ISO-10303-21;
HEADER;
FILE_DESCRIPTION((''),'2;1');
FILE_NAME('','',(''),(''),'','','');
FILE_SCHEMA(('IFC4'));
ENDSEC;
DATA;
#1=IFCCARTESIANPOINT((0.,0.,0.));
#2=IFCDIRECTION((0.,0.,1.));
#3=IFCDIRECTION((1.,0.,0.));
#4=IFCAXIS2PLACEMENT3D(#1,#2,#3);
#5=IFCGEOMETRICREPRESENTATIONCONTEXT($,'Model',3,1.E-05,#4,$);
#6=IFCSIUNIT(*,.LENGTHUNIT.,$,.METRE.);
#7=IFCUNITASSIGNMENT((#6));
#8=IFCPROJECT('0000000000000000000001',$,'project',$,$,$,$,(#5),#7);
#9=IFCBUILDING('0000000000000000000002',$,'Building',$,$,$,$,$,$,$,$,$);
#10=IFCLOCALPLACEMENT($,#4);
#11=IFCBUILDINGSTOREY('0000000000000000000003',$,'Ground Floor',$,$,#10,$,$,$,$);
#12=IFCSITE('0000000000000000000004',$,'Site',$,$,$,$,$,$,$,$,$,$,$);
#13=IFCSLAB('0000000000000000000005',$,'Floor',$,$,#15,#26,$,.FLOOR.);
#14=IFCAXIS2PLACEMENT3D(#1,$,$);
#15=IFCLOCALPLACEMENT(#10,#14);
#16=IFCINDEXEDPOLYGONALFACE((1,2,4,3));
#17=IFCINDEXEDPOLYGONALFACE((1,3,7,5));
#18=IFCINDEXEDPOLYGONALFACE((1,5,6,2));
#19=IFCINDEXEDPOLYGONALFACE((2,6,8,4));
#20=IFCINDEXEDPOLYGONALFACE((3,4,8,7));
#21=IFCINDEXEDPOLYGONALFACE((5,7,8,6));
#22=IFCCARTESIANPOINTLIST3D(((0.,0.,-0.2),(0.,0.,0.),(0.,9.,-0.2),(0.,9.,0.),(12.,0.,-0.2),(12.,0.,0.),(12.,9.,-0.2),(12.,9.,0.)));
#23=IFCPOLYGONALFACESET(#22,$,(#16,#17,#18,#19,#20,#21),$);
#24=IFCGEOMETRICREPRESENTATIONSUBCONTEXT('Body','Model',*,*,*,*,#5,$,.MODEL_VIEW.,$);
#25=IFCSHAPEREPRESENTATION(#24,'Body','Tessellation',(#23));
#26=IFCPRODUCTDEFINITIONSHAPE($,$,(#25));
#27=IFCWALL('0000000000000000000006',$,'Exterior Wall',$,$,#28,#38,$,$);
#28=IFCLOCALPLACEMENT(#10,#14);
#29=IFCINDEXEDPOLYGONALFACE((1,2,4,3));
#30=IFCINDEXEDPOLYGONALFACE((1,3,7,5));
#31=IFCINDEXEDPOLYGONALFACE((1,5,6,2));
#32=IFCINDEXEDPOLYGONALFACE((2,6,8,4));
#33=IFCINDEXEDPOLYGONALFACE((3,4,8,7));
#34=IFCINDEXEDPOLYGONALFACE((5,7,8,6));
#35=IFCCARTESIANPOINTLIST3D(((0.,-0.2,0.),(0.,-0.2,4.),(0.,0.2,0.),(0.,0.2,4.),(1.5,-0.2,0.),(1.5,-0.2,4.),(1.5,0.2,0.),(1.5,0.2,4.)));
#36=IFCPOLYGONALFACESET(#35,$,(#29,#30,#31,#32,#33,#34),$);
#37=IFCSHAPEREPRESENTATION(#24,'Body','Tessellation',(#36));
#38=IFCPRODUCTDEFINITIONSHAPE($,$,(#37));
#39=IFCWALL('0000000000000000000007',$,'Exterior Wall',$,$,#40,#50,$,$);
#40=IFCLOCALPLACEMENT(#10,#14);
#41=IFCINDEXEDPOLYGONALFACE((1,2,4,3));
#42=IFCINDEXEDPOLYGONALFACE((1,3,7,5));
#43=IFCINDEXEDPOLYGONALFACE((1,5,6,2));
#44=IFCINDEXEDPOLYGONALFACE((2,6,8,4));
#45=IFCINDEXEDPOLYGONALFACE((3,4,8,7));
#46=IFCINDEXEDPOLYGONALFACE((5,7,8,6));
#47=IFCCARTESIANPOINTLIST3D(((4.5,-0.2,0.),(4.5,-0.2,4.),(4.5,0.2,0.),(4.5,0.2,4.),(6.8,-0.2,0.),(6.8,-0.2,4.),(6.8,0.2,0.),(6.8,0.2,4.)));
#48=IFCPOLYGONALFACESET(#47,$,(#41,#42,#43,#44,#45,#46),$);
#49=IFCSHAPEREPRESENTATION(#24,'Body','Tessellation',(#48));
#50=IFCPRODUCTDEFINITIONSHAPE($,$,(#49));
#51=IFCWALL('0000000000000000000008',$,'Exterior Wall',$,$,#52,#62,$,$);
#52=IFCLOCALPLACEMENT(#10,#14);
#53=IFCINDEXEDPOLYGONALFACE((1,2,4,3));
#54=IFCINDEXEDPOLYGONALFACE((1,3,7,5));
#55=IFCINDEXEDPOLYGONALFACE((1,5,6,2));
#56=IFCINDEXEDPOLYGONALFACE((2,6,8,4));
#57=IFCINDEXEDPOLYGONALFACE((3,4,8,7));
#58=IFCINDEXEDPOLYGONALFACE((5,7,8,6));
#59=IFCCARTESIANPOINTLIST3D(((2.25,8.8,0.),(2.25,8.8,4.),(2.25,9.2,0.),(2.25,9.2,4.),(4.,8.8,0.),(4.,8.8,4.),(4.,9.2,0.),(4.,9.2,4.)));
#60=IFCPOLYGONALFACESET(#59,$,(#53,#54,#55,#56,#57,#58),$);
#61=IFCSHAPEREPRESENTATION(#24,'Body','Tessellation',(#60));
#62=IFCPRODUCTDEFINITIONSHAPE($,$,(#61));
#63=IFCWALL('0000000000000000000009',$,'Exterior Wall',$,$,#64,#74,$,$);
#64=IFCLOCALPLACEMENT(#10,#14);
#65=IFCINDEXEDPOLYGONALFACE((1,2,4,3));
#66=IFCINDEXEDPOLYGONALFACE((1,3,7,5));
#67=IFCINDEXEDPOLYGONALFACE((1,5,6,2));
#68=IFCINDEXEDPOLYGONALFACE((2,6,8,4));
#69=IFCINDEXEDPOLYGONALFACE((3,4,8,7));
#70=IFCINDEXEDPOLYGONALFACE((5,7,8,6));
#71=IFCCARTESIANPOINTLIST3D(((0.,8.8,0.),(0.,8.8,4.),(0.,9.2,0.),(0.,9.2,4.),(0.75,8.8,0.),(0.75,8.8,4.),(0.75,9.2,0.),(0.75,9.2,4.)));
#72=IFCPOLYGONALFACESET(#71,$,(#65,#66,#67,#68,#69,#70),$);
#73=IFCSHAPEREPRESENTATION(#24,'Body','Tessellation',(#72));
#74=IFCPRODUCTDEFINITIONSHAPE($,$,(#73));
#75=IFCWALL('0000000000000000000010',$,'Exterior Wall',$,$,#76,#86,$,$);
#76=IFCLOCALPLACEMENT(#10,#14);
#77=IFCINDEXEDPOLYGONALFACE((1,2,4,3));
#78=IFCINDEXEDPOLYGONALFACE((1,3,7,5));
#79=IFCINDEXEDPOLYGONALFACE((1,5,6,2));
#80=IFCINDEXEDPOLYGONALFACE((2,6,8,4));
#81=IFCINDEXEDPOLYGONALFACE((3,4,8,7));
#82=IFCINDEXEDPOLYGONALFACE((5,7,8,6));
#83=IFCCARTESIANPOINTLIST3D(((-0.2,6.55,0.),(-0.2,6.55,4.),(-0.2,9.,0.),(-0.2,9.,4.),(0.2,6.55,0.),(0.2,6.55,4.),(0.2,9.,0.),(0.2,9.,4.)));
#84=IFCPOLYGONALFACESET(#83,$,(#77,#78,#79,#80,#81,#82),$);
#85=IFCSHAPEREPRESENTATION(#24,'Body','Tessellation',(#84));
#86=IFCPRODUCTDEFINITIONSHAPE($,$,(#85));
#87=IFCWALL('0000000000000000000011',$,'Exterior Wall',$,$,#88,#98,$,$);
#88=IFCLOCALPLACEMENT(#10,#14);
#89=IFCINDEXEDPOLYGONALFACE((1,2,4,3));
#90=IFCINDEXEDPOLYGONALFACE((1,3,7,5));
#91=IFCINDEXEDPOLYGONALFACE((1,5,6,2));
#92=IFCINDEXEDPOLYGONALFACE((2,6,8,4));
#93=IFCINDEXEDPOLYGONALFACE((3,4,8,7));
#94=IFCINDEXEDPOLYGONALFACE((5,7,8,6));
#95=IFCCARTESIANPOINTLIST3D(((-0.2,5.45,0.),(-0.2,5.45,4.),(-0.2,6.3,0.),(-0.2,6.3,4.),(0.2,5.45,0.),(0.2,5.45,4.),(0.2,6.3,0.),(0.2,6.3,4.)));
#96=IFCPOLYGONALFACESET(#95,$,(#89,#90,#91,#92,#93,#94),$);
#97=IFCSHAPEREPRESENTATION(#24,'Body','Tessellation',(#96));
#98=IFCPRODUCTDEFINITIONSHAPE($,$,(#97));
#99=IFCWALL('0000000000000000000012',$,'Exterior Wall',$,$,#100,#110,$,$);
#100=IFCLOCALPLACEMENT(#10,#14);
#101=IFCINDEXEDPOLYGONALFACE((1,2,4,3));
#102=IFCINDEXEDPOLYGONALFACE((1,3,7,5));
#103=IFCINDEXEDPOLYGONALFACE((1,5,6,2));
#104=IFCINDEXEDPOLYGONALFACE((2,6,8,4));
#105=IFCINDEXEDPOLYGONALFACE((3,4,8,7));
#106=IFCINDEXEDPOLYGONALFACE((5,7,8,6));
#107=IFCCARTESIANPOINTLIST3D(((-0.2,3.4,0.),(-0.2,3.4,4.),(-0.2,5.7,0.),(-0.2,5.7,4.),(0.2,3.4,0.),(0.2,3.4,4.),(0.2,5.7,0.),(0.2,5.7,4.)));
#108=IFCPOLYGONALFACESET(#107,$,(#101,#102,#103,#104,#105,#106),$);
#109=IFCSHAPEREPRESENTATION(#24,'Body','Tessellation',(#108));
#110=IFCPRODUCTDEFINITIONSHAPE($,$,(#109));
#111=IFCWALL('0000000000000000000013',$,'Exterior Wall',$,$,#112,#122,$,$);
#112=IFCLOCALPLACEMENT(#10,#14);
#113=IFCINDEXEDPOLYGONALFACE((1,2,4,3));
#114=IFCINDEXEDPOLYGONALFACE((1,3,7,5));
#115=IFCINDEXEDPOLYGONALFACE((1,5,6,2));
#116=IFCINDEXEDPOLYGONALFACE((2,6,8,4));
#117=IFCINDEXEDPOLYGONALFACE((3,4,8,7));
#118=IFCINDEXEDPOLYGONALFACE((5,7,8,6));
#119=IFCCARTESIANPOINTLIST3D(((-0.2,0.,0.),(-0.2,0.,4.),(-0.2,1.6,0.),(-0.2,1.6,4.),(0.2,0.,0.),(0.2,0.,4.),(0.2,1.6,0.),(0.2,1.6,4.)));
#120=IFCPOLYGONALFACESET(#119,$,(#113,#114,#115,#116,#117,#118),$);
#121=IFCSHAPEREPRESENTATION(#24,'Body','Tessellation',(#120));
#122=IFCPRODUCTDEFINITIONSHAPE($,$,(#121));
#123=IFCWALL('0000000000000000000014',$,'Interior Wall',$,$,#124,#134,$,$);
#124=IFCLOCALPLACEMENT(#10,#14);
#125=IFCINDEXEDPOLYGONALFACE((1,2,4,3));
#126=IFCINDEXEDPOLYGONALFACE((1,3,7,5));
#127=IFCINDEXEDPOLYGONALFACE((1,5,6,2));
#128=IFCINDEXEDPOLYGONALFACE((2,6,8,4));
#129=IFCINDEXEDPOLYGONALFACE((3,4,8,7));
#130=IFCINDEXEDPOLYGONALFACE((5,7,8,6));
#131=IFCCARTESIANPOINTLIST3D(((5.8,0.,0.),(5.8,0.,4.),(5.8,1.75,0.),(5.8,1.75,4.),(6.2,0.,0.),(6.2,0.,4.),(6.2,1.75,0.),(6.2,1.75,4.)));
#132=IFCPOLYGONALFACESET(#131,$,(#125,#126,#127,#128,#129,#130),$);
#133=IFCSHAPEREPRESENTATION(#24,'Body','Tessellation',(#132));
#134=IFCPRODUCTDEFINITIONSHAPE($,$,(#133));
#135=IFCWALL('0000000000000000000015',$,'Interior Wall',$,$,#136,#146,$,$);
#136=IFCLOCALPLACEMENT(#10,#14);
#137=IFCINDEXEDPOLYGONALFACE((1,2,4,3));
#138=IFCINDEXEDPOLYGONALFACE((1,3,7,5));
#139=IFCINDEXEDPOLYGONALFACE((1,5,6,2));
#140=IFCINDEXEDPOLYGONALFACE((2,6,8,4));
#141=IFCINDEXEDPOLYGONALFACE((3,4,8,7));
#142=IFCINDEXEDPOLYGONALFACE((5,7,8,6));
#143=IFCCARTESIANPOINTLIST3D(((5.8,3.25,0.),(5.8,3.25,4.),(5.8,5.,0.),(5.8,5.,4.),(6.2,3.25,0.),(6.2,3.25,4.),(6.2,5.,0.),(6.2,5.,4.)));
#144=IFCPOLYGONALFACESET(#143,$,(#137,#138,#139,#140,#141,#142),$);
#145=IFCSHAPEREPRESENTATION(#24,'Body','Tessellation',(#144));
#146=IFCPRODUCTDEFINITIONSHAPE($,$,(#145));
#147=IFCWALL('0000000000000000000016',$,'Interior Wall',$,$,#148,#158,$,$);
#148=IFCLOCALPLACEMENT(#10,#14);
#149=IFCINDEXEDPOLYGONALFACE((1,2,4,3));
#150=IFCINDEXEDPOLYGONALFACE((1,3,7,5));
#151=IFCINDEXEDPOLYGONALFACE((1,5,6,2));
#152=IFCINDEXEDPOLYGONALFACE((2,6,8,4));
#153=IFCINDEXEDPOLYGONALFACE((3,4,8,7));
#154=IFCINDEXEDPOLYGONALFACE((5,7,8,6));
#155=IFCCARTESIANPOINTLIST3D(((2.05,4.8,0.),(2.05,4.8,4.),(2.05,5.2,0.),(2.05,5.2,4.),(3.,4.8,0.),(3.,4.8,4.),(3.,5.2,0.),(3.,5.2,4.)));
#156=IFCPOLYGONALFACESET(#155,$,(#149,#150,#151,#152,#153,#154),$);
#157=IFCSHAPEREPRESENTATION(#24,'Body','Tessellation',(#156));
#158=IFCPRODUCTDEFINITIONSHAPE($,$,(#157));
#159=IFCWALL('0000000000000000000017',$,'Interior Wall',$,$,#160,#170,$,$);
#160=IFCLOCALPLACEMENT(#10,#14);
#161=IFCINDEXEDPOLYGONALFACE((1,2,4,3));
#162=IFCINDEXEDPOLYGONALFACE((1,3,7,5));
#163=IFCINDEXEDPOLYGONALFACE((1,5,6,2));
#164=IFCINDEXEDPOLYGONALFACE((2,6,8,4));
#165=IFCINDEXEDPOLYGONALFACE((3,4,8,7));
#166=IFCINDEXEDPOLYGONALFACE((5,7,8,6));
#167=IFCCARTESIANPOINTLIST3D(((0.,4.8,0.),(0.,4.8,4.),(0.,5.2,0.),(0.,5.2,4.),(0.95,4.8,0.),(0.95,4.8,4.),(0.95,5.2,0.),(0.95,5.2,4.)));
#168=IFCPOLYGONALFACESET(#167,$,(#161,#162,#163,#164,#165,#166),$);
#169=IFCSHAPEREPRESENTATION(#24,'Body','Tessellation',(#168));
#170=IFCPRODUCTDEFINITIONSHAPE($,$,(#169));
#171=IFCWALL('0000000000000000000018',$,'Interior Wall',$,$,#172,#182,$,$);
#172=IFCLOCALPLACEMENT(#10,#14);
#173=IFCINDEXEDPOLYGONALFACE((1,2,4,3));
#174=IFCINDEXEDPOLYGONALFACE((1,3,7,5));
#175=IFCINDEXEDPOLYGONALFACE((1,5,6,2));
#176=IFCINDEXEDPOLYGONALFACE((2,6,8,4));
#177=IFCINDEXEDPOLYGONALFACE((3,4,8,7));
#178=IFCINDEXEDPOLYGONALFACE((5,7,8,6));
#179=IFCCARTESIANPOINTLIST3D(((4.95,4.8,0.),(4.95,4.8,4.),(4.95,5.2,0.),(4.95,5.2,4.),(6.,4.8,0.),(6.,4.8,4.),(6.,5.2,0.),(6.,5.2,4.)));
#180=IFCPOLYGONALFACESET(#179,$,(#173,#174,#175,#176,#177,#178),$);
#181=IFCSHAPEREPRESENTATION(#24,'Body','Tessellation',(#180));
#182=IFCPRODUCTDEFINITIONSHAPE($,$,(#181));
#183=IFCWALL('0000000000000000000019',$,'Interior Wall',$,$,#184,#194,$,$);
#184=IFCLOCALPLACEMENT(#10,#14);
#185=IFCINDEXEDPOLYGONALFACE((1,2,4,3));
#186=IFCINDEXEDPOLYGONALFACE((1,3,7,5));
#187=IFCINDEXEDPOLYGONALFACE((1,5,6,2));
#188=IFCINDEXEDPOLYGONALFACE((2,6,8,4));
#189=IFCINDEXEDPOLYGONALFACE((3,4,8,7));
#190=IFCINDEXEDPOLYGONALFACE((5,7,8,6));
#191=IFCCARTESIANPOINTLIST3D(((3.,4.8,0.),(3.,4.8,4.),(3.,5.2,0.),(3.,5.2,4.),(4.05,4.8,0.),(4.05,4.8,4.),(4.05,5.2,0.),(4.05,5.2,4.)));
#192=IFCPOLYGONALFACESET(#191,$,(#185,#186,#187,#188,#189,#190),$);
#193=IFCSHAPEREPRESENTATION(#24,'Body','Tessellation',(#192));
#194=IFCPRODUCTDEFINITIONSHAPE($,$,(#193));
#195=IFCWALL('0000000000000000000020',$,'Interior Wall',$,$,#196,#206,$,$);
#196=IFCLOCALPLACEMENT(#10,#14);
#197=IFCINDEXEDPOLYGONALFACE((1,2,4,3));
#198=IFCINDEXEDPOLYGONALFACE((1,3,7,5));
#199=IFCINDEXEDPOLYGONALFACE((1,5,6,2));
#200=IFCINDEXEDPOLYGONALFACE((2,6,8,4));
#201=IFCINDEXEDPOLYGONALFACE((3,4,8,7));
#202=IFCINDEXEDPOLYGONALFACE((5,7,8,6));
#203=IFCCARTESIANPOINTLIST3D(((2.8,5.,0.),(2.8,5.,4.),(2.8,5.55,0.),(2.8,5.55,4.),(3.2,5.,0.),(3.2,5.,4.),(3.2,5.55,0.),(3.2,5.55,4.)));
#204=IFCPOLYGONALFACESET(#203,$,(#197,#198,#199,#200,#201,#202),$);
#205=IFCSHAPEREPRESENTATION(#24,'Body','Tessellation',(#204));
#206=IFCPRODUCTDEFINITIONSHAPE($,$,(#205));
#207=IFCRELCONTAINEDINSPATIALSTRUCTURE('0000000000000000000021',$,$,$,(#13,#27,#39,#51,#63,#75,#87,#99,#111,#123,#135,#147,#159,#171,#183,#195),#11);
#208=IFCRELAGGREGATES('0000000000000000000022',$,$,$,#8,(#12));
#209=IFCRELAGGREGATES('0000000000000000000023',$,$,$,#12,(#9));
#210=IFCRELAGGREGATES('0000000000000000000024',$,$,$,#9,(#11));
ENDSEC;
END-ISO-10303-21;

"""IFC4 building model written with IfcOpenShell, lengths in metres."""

from ifc_helpers import new_model, si_unit, frame, origin_with_axes, place, context, subcontext, project, spatial, indexed_curve, outline, extrude, element, save


model = new_model("IFC4")

# Units and contexts
model_context = context("Model", 3, precision=1e-05, world=origin_with_axes())
body_context = subcontext(model_context, "Body", "Model", "MODEL_VIEW")
ifc_project = project(units=[si_unit("LENGTHUNIT", "METRE")], contexts=[model_context])

# Site, building, storey
site = spatial("IfcSite", under=ifc_project, Name="Site")
building = spatial("IfcBuilding", under=site, Name="Building")
storey_placement = place(None, origin_with_axes())
storey = spatial("IfcBuildingStorey", under=building, at=storey_placement, Name="Ground Floor")

# Slab
slab_placement = place(storey_placement, frame((0.0, 0.0, -0.2), z_axis=(0.0, 0.0, 1.0), x_axis=(1.0, 0.0, 0.0)))
element("IfcSlab", 1, at=slab_placement, inside=storey, Name="Floor", PredefinedType="FLOOR", context=body_context, shape_type="SweptSolid", body=[
    extrude(outline(indexed_curve([(0.0, 0.0), (12.0, 0.0), (12.0, 9.0), (0.0, 9.0)])), None, (0.0, 0.0, 1.0), 0.2),
])

# Walls
wall_1_placement = place(storey_placement, origin_with_axes())
element("IfcWall", 2, at=wall_1_placement, inside=storey, Name="Exterior Wall", context=body_context, shape_type="SweptSolid", body=[
    extrude(outline(indexed_curve([(0.0, 0.0), (0.0, 0.4), (1.5, 0.4), (1.5, 0.0), (0.0, 0.0)], self_intersect=False)), frame((0.0, -0.2, 0.0), z_axis=(0.0, 0.0, 1.0), x_axis=(1.0, 0.0, 0.0)), (0.0, 0.0, 1.0), 4.0),
])
wall_2_placement = place(storey_placement, frame((4.5, 0.0, 0.0), z_axis=(0.0, 0.0, 1.0), x_axis=(1.0, 0.0, 0.0)))
element("IfcWall", 3, at=wall_2_placement, inside=storey, Name="Exterior Wall", context=body_context, shape_type="SweptSolid", body=[
    extrude(outline(indexed_curve([(0.0, 0.0), (0.0, 0.4), (2.3, 0.4), (2.3, 0.0), (0.0, 0.0)], self_intersect=False)), frame((0.0, -0.2, 0.0), z_axis=(0.0, 0.0, 1.0), x_axis=(1.0, 0.0, 0.0)), (0.0, 0.0, 1.0), 4.0),
])
wall_3_placement = place(storey_placement, frame((4.0, 9.0, 0.0), z_axis=(0.0, 0.0, 1.0), x_axis=(-1.0, 0.0, 0.0)))
element("IfcWall", 4, at=wall_3_placement, inside=storey, Name="Exterior Wall", context=body_context, shape_type="SweptSolid", body=[
    extrude(outline(indexed_curve([(0.0, 0.0), (0.0, 0.4), (1.75, 0.4), (1.75, 0.0), (0.0, 0.0)], self_intersect=False)), frame((0.0, -0.2, 0.0), z_axis=(0.0, 0.0, 1.0), x_axis=(1.0, 0.0, 0.0)), (0.0, 0.0, 1.0), 4.0),
])
wall_4_placement = place(storey_placement, frame((0.75, 9.0, 0.0), z_axis=(0.0, 0.0, 1.0), x_axis=(-1.0, 0.0, 0.0)))
element("IfcWall", 5, at=wall_4_placement, inside=storey, Name="Exterior Wall", context=body_context, shape_type="SweptSolid", body=[
    extrude(outline(indexed_curve([(0.0, 0.0), (0.0, 0.4), (0.75, 0.4), (0.75, 0.0), (0.0, 0.0)], self_intersect=False)), frame((0.0, -0.2, 0.0), z_axis=(0.0, 0.0, 1.0), x_axis=(1.0, 0.0, 0.0)), (0.0, 0.0, 1.0), 4.0),
])
wall_5_placement = place(storey_placement, frame((0.0, 9.0, 0.0), z_axis=(0.0, 0.0, 1.0), x_axis=(0.0, -1.0, 0.0)))
element("IfcWall", 6, at=wall_5_placement, inside=storey, Name="Exterior Wall", context=body_context, shape_type="SweptSolid", body=[
    extrude(outline(indexed_curve([(0.0, 0.0), (0.0, 0.4), (2.45, 0.4), (2.45, 0.0), (0.0, 0.0)], self_intersect=False)), frame((0.0, -0.2, 0.0), z_axis=(0.0, 0.0, 1.0), x_axis=(1.0, 0.0, 0.0)), (0.0, 0.0, 1.0), 4.0),
])
wall_6_placement = place(storey_placement, frame((0.0, 5.45, 0.0), z_axis=(0.0, 0.0, 1.0), x_axis=(0.0, 1.0, 0.0)))
element("IfcWall", 7, at=wall_6_placement, inside=storey, Name="Exterior Wall", context=body_context, shape_type="SweptSolid", body=[
    extrude(outline(indexed_curve([(0.0, 0.0), (0.0, 0.4), (0.85, 0.4), (0.85, 0.0), (0.0, 0.0)], self_intersect=False)), frame((0.0, -0.2, 0.0), z_axis=(0.0, 0.0, 1.0), x_axis=(1.0, 0.0, 0.0)), (0.0, 0.0, 1.0), 4.0),
])
wall_7_placement = place(storey_placement, frame((0.0, 5.7, 0.0), z_axis=(0.0, 0.0, 1.0), x_axis=(0.0, -1.0, 0.0)))
element("IfcWall", 8, at=wall_7_placement, inside=storey, Name="Exterior Wall", context=body_context, shape_type="SweptSolid", body=[
    extrude(outline(indexed_curve([(0.0, 0.0), (0.0, 0.4), (2.3, 0.4), (2.3, 0.0), (0.0, 0.0)], self_intersect=False)), frame((0.0, -0.2, 0.0), z_axis=(0.0, 0.0, 1.0), x_axis=(1.0, 0.0, 0.0)), (0.0, 0.0, 1.0), 4.0),
])
wall_8_placement = place(storey_placement, frame((0.0, 1.6, 0.0), z_axis=(0.0, 0.0, 1.0), x_axis=(0.0, -1.0, 0.0)))
element("IfcWall", 9, at=wall_8_placement, inside=storey, Name="Exterior Wall", context=body_context, shape_type="SweptSolid", body=[
    extrude(outline(indexed_curve([(0.0, 0.0), (0.0, 0.4), (1.6, 0.4), (1.6, 0.0), (0.0, 0.0)], self_intersect=False)), frame((0.0, -0.2, 0.0), z_axis=(0.0, 0.0, 1.0), x_axis=(1.0, 0.0, 0.0)), (0.0, 0.0, 1.0), 4.0),
])
for number, where, z_axis, x_axis, name in (
    (10, (6.0, 0.0, 0.0), (0.0, 0.0, 1.0), (0.0, 1.0, 0.0), "Interior Wall"),
    (11, (6.0, 3.25, 0.0), (0.0, 0.0, 1.0), (0.0, 1.0, 0.0), "Interior Wall"),
):
    element("IfcWall", number, at=place(storey_placement, frame(where, z_axis=z_axis, x_axis=x_axis)), inside=storey, Name=name, context=body_context, shape_type="SweptSolid", body=[
        extrude(outline(indexed_curve([(0.0, 0.0), (0.0, 0.4), (1.75, 0.4), (1.75, 0.0), (0.0, 0.0)], self_intersect=False)), frame((0.0, -0.2, 0.0), z_axis=(0.0, 0.0, 1.0), x_axis=(1.0, 0.0, 0.0)), (0.0, 0.0, 1.0), 4.0),
    ])
for number, where, z_axis, x_axis, name in (
    (12, (3.0, 5.0, 0.0), (0.0, 0.0, 1.0), (-1.0, 0.0, 0.0), "Interior Wall"),
    (13, (0.95, 5.0, 0.0), (0.0, 0.0, 1.0), (-1.0, 0.0, 0.0), "Interior Wall"),
):
    element("IfcWall", number, at=place(storey_placement, frame(where, z_axis=z_axis, x_axis=x_axis)), inside=storey, Name=name, context=body_context, shape_type="SweptSolid", body=[
        extrude(outline(indexed_curve([(0.0, 0.0), (0.0, 0.4), (0.95, 0.4), (0.95, 0.0), (0.0, 0.0)], self_intersect=False)), frame((0.0, -0.2, 0.0), z_axis=(0.0, 0.0, 1.0), x_axis=(1.0, 0.0, 0.0)), (0.0, 0.0, 1.0), 4.0),
    ])
for number, where, z_axis, x_axis, name in (
    (14, (6.0, 5.0, 0.0), (0.0, 0.0, 1.0), (-1.0, 0.0, 0.0), "Interior Wall"),
    (15, (4.05, 5.0, 0.0), (0.0, 0.0, 1.0), (-1.0, 0.0, 0.0), "Interior Wall"),
):
    element("IfcWall", number, at=place(storey_placement, frame(where, z_axis=z_axis, x_axis=x_axis)), inside=storey, Name=name, context=body_context, shape_type="SweptSolid", body=[
        extrude(outline(indexed_curve([(0.0, 0.0), (0.0, 0.4), (1.05, 0.4), (1.05, 0.0), (0.0, 0.0)], self_intersect=False)), frame((0.0, -0.2, 0.0), z_axis=(0.0, 0.0, 1.0), x_axis=(1.0, 0.0, 0.0)), (0.0, 0.0, 1.0), 4.0),
    ])
for number, where, z_axis, x_axis, name in (
    (16, (3.0, 5.0, 0.0), (0.0, 0.0, 1.0), (0.0, 1.0, 0.0), "Interior Wall"),
):
    element("IfcWall", number, at=place(storey_placement, frame(where, z_axis=z_axis, x_axis=x_axis)), inside=storey, Name=name, context=body_context, shape_type="SweptSolid", body=[
        extrude(outline(indexed_curve([(0.0, 0.0), (0.0, 0.4), (0.55, 0.4), (0.55, 0.0), (0.0, 0.0)], self_intersect=False)), frame((0.0, -0.2, 0.0), z_axis=(0.0, 0.0, 1.0), x_axis=(1.0, 0.0, 0.0)), (0.0, 0.0, 1.0), 4.0),
    ])

save(model, "model.ifc")
